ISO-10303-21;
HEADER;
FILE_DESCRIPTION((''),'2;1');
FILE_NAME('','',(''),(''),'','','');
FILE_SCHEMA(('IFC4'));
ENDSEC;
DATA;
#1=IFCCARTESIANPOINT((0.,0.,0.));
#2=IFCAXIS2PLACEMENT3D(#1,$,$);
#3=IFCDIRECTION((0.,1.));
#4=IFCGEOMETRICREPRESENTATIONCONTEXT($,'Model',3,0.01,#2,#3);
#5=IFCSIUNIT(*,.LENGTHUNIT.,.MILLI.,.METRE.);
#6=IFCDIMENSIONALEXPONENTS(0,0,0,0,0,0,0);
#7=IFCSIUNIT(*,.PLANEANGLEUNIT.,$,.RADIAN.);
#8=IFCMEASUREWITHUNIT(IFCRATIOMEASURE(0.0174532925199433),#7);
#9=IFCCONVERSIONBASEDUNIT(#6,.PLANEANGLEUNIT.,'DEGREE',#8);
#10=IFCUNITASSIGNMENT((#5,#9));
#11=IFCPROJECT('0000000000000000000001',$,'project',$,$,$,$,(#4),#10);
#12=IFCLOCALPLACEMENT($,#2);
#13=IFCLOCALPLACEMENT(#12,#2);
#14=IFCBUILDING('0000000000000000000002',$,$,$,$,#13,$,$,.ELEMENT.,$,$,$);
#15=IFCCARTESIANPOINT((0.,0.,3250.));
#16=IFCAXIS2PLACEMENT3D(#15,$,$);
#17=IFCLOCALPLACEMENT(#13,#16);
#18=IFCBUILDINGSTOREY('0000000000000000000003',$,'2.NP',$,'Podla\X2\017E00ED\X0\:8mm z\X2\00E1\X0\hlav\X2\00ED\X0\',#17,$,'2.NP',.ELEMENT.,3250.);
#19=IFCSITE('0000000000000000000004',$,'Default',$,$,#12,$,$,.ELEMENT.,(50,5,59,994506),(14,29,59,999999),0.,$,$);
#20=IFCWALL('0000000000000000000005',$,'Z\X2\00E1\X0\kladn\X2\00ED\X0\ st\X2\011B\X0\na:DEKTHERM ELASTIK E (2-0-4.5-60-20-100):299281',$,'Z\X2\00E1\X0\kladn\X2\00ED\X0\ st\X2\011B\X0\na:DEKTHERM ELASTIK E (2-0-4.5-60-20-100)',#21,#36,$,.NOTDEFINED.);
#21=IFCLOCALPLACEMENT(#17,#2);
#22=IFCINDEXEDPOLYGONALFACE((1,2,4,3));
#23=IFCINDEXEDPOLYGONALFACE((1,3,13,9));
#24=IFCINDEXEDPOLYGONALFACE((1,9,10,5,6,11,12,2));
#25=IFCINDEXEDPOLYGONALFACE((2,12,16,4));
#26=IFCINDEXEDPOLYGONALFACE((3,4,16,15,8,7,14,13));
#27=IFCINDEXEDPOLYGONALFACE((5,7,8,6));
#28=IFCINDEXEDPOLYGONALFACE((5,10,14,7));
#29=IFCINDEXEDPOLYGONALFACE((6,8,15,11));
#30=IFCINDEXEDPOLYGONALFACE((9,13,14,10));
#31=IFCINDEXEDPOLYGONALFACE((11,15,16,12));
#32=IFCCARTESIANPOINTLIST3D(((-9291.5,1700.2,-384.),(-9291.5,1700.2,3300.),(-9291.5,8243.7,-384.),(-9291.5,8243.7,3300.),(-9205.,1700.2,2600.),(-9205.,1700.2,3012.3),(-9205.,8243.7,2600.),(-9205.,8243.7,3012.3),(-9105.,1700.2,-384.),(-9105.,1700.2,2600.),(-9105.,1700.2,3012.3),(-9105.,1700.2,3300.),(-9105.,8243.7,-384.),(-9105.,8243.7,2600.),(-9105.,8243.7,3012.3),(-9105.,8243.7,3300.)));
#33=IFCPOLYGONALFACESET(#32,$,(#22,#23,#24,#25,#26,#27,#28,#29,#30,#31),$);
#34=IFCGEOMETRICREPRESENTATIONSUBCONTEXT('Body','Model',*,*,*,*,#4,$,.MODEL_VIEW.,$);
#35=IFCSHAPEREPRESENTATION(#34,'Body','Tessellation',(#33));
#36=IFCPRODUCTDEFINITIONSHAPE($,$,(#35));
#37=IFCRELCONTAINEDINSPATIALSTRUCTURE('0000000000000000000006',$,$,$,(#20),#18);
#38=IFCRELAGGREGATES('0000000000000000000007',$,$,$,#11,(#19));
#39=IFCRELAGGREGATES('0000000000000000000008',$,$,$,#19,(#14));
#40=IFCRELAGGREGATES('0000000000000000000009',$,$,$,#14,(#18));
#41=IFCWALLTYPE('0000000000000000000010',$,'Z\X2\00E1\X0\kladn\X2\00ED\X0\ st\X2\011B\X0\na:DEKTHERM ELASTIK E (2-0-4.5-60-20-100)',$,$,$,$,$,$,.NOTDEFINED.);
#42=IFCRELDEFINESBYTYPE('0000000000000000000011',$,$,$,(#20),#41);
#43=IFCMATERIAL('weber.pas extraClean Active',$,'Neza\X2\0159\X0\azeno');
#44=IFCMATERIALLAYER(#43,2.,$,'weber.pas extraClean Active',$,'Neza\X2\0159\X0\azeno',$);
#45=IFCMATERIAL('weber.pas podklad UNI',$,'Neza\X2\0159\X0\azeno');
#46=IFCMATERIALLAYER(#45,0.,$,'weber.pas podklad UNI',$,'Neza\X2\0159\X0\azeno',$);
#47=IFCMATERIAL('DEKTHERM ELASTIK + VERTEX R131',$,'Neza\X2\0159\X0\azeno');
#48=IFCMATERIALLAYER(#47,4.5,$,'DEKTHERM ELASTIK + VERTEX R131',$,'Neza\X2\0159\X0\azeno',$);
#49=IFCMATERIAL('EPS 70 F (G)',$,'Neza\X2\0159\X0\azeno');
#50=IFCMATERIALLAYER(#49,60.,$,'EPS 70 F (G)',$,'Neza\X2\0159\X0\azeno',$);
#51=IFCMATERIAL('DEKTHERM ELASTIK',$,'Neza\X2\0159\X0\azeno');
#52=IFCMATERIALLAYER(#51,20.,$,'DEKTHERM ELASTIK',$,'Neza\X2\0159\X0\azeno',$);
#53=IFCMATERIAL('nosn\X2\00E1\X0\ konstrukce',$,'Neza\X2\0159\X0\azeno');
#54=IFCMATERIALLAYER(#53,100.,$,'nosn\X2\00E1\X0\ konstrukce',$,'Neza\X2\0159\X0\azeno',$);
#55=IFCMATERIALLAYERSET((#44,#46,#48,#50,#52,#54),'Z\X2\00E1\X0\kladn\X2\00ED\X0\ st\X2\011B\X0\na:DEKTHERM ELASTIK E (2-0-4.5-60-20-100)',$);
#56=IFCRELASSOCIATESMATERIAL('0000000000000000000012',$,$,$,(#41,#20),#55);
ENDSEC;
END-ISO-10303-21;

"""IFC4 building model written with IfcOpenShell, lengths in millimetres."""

from ifc_helpers import new_model, entity, si_unit, converted_unit, direction, frame, frame_2d, origin, place, context, subcontext, project, spatial, polyline, rectangle, extrude, clip, bounded_halfspace, material, layer, layer_set, layer_usage, type_object, element, save


model = new_model("IFC4")

# Units and contexts
model_context = context("Model", 3, precision=0.01, world=origin(), true_north=direction((0.0, 1.0)))
body_context = subcontext(model_context, "Body", "Model", "MODEL_VIEW")
ifc_project = project(units=[si_unit("LENGTHUNIT", "METRE", prefix="MILLI"), converted_unit("PLANEANGLEUNIT", "DEGREE", entity("IfcRatioMeasure", 0.0174532925199433), si_unit("PLANEANGLEUNIT", "RADIAN"), dimensions=[0, 0, 0, 0, 0, 0, 0])], contexts=[model_context])

# Site, building, storey
site_placement = place(None, origin())
site = spatial("IfcSite", under=ifc_project, at=site_placement, Name="Default", CompositionType="ELEMENT", RefLatitude=(50, 5, 59, 994506), RefLongitude=(14, 29, 59, 999999), RefElevation=0.0)
building_placement = place(site_placement, origin())
building = spatial("IfcBuilding", under=site, at=building_placement, CompositionType="ELEMENT")
storey_placement = place(building_placement, frame((0.0, 0.0, 3250.0)))
storey = spatial("IfcBuildingStorey", under=building, at=storey_placement, Name="2.NP", ObjectType="Podlaží:8mm záhlaví", LongName="2.NP", CompositionType="ELEMENT", Elevation=3250.0)

# Shared definitions
ifc_material_1 = material(Name="weber.pas extraClean Active", Category="Nezařazeno")
ifc_layer_1 = layer(ifc_material_1, 2.0, Name="weber.pas extraClean Active", Category="Nezařazeno")
ifc_material_2 = material(Name="weber.pas podklad UNI", Category="Nezařazeno")
ifc_layer_2 = layer(ifc_material_2, 0.0, Name="weber.pas podklad UNI", Category="Nezařazeno")
ifc_material_3 = material(Name="DEKTHERM ELASTIK + VERTEX R131", Category="Nezařazeno")
ifc_layer_3 = layer(ifc_material_3, 4.5, Name="DEKTHERM ELASTIK + VERTEX R131", Category="Nezařazeno")
ifc_material_4 = material(Name="EPS 70 F (G)", Category="Nezařazeno")
ifc_layer_4 = layer(ifc_material_4, 60.0, Name="EPS 70 F (G)", Category="Nezařazeno")
ifc_material_5 = material(Name="DEKTHERM ELASTIK", Category="Nezařazeno")
ifc_layer_5 = layer(ifc_material_5, 20.0, Name="DEKTHERM ELASTIK", Category="Nezařazeno")
ifc_material_6 = material(Name="nosná konstrukce", Category="Nezařazeno")
ifc_layer_6 = layer(ifc_material_6, 100.0, Name="nosná konstrukce", Category="Nezařazeno")
ifc_layer_set_1 = layer_set([ifc_layer_1, ifc_layer_2, ifc_layer_3, ifc_layer_4, ifc_layer_5, ifc_layer_6], Name="Základní stěna:DEKTHERM ELASTIK E (2-0-4.5-60-20-100)")
wall_type = type_object("IfcWallType", Name="Základní stěna:DEKTHERM ELASTIK E (2-0-4.5-60-20-100)", PredefinedType="NOTDEFINED", material=ifc_layer_set_1)

# Wall
ifc_layer_usage_1 = layer_usage(ifc_layer_set_1, "AXIS2", "NEGATIVE", 93.2)
wall_1_placement = place(storey_placement, frame((-9198.2, 1700.2, -384.0), z_axis=(0.0, 0.0, 1.0), x_axis=(0.0, 1.0, 0.0)))
element("IfcWall", 1, at=wall_1_placement, inside=storey, type_object=wall_type, material=ifc_layer_usage_1, Name="Základní stěna:DEKTHERM ELASTIK E (2-0-4.5-60-20-100):299281", ObjectType="Základní stěna:DEKTHERM ELASTIK E (2-0-4.5-60-20-100)", PredefinedType="NOTDEFINED", context=body_context, shape_type="Clipping", body=[
    clip(extrude(rectangle(XDim=6543.5, YDim=186.5, at=frame_2d((3271.8, 0.0), x_axis=(-1.0, 0.0))), origin(), (0.0, 0.0, 1.0), 3684.0), bounded_halfspace(frame((0.0, 6.7, 2984.0), z_axis=(0.0, 1.0, 0.0), x_axis=(-1.0, 0.0, 0.0)), True, frame((0.0, 6.7, 2984.0), z_axis=(0.0, 1.0, 0.0), x_axis=(-1.0, 0.0, 0.0)), polyline([(0.0, 0.0), (0.0, 412.3), (-6543.5, 412.3), (-6543.5, 0.0), (0.0, 0.0)]))),
])

save(model, "model.ifc")
